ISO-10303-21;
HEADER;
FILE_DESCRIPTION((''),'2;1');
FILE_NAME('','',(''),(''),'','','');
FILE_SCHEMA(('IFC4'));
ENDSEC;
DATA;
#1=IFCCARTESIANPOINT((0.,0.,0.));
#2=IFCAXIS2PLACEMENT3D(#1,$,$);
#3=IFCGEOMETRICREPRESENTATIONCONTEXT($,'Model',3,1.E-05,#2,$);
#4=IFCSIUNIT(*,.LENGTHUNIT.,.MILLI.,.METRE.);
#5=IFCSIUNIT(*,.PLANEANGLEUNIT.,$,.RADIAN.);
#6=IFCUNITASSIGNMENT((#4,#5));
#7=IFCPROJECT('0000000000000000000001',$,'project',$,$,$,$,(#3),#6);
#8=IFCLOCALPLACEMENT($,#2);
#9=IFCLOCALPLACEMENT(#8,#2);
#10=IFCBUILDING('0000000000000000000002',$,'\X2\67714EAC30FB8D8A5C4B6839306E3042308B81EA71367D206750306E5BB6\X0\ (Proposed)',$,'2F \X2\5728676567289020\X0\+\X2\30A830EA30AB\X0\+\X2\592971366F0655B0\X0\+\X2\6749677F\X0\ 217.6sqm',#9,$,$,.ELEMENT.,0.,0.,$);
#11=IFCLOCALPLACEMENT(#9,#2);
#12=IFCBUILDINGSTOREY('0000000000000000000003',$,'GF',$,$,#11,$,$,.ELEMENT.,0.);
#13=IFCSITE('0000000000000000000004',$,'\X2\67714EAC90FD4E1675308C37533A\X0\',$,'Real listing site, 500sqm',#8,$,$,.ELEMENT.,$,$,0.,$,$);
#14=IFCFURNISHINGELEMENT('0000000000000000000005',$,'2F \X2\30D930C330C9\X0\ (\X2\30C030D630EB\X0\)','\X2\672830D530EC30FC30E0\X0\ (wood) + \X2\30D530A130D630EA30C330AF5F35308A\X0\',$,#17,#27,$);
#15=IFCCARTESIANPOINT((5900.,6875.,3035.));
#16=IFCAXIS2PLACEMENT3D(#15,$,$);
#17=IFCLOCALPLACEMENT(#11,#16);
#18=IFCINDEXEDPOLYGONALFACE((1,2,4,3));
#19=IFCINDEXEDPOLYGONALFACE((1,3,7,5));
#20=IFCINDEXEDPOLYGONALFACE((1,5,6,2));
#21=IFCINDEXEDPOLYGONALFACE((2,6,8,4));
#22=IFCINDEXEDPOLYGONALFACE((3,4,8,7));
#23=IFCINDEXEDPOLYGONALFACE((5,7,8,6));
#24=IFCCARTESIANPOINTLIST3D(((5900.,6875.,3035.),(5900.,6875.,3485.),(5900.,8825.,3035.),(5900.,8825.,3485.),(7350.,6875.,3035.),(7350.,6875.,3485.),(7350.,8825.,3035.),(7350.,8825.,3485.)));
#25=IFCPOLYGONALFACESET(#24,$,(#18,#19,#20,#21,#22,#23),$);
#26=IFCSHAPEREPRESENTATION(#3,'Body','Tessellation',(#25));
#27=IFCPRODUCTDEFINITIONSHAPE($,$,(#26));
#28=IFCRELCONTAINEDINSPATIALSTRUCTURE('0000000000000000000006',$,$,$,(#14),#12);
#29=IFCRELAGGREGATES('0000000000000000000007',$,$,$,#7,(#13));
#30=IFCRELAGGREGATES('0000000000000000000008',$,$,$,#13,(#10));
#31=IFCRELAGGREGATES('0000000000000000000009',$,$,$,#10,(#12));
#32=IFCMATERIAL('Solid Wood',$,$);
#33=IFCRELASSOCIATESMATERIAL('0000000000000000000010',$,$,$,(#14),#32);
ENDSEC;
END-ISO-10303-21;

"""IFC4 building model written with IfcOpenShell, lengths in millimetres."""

from ifc_helpers import new_model, si_unit, frame, frame_2d, origin, place, context, project, spatial, rectangle, extrude, material, element, save


model = new_model("IFC4")

# Units and contexts
model_context = context("Model", 3, precision=1e-05, world=origin())
ifc_project = project(units=[si_unit("LENGTHUNIT", "METRE", prefix="MILLI"), si_unit("PLANEANGLEUNIT", "RADIAN")], contexts=[model_context])

# Site, building, storey
site_placement = place(None, origin())
site = spatial("IfcSite", under=ifc_project, at=site_placement, Name="東京都世田谷区", ObjectType="Real listing site, 500sqm", CompositionType="ELEMENT", RefElevation=0.0)
building_placement = place(site_placement, origin())
building = spatial("IfcBuilding", under=site, at=building_placement, Name="東京・越屋根のある自然素材の家 (Proposed)", ObjectType="2F 在来木造+エリカ+天然漆喰+杉板 217.6sqm", CompositionType="ELEMENT", ElevationOfRefHeight=0.0, ElevationOfTerrain=0.0)
storey_placement = place(building_placement, origin())
storey = spatial("IfcBuildingStorey", under=building, at=storey_placement, Name="GF", CompositionType="ELEMENT", Elevation=0.0)

# Shared definitions
ifc_material_1 = material(Name="Solid Wood")

# Furnishing element
furnishing_1_placement = place(storey_placement, frame((5900.0, 6875.0, 3035.0)))
element("IfcFurnishingElement", 1, at=furnishing_1_placement, inside=storey, material=ifc_material_1, Name="2F ベッド (ダブル)", Description="木フレーム (wood) + ファブリック張り", context=model_context, shape_type="SweptSolid", body=[
    extrude(rectangle(XDim=1450.0, YDim=1950.0, at=frame_2d((725.0, 975.0))), frame((5900.0, 6875.0, 3035.0)), (0.0, 0.0, 1.0), 450.0),
])

save(model, "model.ifc")
